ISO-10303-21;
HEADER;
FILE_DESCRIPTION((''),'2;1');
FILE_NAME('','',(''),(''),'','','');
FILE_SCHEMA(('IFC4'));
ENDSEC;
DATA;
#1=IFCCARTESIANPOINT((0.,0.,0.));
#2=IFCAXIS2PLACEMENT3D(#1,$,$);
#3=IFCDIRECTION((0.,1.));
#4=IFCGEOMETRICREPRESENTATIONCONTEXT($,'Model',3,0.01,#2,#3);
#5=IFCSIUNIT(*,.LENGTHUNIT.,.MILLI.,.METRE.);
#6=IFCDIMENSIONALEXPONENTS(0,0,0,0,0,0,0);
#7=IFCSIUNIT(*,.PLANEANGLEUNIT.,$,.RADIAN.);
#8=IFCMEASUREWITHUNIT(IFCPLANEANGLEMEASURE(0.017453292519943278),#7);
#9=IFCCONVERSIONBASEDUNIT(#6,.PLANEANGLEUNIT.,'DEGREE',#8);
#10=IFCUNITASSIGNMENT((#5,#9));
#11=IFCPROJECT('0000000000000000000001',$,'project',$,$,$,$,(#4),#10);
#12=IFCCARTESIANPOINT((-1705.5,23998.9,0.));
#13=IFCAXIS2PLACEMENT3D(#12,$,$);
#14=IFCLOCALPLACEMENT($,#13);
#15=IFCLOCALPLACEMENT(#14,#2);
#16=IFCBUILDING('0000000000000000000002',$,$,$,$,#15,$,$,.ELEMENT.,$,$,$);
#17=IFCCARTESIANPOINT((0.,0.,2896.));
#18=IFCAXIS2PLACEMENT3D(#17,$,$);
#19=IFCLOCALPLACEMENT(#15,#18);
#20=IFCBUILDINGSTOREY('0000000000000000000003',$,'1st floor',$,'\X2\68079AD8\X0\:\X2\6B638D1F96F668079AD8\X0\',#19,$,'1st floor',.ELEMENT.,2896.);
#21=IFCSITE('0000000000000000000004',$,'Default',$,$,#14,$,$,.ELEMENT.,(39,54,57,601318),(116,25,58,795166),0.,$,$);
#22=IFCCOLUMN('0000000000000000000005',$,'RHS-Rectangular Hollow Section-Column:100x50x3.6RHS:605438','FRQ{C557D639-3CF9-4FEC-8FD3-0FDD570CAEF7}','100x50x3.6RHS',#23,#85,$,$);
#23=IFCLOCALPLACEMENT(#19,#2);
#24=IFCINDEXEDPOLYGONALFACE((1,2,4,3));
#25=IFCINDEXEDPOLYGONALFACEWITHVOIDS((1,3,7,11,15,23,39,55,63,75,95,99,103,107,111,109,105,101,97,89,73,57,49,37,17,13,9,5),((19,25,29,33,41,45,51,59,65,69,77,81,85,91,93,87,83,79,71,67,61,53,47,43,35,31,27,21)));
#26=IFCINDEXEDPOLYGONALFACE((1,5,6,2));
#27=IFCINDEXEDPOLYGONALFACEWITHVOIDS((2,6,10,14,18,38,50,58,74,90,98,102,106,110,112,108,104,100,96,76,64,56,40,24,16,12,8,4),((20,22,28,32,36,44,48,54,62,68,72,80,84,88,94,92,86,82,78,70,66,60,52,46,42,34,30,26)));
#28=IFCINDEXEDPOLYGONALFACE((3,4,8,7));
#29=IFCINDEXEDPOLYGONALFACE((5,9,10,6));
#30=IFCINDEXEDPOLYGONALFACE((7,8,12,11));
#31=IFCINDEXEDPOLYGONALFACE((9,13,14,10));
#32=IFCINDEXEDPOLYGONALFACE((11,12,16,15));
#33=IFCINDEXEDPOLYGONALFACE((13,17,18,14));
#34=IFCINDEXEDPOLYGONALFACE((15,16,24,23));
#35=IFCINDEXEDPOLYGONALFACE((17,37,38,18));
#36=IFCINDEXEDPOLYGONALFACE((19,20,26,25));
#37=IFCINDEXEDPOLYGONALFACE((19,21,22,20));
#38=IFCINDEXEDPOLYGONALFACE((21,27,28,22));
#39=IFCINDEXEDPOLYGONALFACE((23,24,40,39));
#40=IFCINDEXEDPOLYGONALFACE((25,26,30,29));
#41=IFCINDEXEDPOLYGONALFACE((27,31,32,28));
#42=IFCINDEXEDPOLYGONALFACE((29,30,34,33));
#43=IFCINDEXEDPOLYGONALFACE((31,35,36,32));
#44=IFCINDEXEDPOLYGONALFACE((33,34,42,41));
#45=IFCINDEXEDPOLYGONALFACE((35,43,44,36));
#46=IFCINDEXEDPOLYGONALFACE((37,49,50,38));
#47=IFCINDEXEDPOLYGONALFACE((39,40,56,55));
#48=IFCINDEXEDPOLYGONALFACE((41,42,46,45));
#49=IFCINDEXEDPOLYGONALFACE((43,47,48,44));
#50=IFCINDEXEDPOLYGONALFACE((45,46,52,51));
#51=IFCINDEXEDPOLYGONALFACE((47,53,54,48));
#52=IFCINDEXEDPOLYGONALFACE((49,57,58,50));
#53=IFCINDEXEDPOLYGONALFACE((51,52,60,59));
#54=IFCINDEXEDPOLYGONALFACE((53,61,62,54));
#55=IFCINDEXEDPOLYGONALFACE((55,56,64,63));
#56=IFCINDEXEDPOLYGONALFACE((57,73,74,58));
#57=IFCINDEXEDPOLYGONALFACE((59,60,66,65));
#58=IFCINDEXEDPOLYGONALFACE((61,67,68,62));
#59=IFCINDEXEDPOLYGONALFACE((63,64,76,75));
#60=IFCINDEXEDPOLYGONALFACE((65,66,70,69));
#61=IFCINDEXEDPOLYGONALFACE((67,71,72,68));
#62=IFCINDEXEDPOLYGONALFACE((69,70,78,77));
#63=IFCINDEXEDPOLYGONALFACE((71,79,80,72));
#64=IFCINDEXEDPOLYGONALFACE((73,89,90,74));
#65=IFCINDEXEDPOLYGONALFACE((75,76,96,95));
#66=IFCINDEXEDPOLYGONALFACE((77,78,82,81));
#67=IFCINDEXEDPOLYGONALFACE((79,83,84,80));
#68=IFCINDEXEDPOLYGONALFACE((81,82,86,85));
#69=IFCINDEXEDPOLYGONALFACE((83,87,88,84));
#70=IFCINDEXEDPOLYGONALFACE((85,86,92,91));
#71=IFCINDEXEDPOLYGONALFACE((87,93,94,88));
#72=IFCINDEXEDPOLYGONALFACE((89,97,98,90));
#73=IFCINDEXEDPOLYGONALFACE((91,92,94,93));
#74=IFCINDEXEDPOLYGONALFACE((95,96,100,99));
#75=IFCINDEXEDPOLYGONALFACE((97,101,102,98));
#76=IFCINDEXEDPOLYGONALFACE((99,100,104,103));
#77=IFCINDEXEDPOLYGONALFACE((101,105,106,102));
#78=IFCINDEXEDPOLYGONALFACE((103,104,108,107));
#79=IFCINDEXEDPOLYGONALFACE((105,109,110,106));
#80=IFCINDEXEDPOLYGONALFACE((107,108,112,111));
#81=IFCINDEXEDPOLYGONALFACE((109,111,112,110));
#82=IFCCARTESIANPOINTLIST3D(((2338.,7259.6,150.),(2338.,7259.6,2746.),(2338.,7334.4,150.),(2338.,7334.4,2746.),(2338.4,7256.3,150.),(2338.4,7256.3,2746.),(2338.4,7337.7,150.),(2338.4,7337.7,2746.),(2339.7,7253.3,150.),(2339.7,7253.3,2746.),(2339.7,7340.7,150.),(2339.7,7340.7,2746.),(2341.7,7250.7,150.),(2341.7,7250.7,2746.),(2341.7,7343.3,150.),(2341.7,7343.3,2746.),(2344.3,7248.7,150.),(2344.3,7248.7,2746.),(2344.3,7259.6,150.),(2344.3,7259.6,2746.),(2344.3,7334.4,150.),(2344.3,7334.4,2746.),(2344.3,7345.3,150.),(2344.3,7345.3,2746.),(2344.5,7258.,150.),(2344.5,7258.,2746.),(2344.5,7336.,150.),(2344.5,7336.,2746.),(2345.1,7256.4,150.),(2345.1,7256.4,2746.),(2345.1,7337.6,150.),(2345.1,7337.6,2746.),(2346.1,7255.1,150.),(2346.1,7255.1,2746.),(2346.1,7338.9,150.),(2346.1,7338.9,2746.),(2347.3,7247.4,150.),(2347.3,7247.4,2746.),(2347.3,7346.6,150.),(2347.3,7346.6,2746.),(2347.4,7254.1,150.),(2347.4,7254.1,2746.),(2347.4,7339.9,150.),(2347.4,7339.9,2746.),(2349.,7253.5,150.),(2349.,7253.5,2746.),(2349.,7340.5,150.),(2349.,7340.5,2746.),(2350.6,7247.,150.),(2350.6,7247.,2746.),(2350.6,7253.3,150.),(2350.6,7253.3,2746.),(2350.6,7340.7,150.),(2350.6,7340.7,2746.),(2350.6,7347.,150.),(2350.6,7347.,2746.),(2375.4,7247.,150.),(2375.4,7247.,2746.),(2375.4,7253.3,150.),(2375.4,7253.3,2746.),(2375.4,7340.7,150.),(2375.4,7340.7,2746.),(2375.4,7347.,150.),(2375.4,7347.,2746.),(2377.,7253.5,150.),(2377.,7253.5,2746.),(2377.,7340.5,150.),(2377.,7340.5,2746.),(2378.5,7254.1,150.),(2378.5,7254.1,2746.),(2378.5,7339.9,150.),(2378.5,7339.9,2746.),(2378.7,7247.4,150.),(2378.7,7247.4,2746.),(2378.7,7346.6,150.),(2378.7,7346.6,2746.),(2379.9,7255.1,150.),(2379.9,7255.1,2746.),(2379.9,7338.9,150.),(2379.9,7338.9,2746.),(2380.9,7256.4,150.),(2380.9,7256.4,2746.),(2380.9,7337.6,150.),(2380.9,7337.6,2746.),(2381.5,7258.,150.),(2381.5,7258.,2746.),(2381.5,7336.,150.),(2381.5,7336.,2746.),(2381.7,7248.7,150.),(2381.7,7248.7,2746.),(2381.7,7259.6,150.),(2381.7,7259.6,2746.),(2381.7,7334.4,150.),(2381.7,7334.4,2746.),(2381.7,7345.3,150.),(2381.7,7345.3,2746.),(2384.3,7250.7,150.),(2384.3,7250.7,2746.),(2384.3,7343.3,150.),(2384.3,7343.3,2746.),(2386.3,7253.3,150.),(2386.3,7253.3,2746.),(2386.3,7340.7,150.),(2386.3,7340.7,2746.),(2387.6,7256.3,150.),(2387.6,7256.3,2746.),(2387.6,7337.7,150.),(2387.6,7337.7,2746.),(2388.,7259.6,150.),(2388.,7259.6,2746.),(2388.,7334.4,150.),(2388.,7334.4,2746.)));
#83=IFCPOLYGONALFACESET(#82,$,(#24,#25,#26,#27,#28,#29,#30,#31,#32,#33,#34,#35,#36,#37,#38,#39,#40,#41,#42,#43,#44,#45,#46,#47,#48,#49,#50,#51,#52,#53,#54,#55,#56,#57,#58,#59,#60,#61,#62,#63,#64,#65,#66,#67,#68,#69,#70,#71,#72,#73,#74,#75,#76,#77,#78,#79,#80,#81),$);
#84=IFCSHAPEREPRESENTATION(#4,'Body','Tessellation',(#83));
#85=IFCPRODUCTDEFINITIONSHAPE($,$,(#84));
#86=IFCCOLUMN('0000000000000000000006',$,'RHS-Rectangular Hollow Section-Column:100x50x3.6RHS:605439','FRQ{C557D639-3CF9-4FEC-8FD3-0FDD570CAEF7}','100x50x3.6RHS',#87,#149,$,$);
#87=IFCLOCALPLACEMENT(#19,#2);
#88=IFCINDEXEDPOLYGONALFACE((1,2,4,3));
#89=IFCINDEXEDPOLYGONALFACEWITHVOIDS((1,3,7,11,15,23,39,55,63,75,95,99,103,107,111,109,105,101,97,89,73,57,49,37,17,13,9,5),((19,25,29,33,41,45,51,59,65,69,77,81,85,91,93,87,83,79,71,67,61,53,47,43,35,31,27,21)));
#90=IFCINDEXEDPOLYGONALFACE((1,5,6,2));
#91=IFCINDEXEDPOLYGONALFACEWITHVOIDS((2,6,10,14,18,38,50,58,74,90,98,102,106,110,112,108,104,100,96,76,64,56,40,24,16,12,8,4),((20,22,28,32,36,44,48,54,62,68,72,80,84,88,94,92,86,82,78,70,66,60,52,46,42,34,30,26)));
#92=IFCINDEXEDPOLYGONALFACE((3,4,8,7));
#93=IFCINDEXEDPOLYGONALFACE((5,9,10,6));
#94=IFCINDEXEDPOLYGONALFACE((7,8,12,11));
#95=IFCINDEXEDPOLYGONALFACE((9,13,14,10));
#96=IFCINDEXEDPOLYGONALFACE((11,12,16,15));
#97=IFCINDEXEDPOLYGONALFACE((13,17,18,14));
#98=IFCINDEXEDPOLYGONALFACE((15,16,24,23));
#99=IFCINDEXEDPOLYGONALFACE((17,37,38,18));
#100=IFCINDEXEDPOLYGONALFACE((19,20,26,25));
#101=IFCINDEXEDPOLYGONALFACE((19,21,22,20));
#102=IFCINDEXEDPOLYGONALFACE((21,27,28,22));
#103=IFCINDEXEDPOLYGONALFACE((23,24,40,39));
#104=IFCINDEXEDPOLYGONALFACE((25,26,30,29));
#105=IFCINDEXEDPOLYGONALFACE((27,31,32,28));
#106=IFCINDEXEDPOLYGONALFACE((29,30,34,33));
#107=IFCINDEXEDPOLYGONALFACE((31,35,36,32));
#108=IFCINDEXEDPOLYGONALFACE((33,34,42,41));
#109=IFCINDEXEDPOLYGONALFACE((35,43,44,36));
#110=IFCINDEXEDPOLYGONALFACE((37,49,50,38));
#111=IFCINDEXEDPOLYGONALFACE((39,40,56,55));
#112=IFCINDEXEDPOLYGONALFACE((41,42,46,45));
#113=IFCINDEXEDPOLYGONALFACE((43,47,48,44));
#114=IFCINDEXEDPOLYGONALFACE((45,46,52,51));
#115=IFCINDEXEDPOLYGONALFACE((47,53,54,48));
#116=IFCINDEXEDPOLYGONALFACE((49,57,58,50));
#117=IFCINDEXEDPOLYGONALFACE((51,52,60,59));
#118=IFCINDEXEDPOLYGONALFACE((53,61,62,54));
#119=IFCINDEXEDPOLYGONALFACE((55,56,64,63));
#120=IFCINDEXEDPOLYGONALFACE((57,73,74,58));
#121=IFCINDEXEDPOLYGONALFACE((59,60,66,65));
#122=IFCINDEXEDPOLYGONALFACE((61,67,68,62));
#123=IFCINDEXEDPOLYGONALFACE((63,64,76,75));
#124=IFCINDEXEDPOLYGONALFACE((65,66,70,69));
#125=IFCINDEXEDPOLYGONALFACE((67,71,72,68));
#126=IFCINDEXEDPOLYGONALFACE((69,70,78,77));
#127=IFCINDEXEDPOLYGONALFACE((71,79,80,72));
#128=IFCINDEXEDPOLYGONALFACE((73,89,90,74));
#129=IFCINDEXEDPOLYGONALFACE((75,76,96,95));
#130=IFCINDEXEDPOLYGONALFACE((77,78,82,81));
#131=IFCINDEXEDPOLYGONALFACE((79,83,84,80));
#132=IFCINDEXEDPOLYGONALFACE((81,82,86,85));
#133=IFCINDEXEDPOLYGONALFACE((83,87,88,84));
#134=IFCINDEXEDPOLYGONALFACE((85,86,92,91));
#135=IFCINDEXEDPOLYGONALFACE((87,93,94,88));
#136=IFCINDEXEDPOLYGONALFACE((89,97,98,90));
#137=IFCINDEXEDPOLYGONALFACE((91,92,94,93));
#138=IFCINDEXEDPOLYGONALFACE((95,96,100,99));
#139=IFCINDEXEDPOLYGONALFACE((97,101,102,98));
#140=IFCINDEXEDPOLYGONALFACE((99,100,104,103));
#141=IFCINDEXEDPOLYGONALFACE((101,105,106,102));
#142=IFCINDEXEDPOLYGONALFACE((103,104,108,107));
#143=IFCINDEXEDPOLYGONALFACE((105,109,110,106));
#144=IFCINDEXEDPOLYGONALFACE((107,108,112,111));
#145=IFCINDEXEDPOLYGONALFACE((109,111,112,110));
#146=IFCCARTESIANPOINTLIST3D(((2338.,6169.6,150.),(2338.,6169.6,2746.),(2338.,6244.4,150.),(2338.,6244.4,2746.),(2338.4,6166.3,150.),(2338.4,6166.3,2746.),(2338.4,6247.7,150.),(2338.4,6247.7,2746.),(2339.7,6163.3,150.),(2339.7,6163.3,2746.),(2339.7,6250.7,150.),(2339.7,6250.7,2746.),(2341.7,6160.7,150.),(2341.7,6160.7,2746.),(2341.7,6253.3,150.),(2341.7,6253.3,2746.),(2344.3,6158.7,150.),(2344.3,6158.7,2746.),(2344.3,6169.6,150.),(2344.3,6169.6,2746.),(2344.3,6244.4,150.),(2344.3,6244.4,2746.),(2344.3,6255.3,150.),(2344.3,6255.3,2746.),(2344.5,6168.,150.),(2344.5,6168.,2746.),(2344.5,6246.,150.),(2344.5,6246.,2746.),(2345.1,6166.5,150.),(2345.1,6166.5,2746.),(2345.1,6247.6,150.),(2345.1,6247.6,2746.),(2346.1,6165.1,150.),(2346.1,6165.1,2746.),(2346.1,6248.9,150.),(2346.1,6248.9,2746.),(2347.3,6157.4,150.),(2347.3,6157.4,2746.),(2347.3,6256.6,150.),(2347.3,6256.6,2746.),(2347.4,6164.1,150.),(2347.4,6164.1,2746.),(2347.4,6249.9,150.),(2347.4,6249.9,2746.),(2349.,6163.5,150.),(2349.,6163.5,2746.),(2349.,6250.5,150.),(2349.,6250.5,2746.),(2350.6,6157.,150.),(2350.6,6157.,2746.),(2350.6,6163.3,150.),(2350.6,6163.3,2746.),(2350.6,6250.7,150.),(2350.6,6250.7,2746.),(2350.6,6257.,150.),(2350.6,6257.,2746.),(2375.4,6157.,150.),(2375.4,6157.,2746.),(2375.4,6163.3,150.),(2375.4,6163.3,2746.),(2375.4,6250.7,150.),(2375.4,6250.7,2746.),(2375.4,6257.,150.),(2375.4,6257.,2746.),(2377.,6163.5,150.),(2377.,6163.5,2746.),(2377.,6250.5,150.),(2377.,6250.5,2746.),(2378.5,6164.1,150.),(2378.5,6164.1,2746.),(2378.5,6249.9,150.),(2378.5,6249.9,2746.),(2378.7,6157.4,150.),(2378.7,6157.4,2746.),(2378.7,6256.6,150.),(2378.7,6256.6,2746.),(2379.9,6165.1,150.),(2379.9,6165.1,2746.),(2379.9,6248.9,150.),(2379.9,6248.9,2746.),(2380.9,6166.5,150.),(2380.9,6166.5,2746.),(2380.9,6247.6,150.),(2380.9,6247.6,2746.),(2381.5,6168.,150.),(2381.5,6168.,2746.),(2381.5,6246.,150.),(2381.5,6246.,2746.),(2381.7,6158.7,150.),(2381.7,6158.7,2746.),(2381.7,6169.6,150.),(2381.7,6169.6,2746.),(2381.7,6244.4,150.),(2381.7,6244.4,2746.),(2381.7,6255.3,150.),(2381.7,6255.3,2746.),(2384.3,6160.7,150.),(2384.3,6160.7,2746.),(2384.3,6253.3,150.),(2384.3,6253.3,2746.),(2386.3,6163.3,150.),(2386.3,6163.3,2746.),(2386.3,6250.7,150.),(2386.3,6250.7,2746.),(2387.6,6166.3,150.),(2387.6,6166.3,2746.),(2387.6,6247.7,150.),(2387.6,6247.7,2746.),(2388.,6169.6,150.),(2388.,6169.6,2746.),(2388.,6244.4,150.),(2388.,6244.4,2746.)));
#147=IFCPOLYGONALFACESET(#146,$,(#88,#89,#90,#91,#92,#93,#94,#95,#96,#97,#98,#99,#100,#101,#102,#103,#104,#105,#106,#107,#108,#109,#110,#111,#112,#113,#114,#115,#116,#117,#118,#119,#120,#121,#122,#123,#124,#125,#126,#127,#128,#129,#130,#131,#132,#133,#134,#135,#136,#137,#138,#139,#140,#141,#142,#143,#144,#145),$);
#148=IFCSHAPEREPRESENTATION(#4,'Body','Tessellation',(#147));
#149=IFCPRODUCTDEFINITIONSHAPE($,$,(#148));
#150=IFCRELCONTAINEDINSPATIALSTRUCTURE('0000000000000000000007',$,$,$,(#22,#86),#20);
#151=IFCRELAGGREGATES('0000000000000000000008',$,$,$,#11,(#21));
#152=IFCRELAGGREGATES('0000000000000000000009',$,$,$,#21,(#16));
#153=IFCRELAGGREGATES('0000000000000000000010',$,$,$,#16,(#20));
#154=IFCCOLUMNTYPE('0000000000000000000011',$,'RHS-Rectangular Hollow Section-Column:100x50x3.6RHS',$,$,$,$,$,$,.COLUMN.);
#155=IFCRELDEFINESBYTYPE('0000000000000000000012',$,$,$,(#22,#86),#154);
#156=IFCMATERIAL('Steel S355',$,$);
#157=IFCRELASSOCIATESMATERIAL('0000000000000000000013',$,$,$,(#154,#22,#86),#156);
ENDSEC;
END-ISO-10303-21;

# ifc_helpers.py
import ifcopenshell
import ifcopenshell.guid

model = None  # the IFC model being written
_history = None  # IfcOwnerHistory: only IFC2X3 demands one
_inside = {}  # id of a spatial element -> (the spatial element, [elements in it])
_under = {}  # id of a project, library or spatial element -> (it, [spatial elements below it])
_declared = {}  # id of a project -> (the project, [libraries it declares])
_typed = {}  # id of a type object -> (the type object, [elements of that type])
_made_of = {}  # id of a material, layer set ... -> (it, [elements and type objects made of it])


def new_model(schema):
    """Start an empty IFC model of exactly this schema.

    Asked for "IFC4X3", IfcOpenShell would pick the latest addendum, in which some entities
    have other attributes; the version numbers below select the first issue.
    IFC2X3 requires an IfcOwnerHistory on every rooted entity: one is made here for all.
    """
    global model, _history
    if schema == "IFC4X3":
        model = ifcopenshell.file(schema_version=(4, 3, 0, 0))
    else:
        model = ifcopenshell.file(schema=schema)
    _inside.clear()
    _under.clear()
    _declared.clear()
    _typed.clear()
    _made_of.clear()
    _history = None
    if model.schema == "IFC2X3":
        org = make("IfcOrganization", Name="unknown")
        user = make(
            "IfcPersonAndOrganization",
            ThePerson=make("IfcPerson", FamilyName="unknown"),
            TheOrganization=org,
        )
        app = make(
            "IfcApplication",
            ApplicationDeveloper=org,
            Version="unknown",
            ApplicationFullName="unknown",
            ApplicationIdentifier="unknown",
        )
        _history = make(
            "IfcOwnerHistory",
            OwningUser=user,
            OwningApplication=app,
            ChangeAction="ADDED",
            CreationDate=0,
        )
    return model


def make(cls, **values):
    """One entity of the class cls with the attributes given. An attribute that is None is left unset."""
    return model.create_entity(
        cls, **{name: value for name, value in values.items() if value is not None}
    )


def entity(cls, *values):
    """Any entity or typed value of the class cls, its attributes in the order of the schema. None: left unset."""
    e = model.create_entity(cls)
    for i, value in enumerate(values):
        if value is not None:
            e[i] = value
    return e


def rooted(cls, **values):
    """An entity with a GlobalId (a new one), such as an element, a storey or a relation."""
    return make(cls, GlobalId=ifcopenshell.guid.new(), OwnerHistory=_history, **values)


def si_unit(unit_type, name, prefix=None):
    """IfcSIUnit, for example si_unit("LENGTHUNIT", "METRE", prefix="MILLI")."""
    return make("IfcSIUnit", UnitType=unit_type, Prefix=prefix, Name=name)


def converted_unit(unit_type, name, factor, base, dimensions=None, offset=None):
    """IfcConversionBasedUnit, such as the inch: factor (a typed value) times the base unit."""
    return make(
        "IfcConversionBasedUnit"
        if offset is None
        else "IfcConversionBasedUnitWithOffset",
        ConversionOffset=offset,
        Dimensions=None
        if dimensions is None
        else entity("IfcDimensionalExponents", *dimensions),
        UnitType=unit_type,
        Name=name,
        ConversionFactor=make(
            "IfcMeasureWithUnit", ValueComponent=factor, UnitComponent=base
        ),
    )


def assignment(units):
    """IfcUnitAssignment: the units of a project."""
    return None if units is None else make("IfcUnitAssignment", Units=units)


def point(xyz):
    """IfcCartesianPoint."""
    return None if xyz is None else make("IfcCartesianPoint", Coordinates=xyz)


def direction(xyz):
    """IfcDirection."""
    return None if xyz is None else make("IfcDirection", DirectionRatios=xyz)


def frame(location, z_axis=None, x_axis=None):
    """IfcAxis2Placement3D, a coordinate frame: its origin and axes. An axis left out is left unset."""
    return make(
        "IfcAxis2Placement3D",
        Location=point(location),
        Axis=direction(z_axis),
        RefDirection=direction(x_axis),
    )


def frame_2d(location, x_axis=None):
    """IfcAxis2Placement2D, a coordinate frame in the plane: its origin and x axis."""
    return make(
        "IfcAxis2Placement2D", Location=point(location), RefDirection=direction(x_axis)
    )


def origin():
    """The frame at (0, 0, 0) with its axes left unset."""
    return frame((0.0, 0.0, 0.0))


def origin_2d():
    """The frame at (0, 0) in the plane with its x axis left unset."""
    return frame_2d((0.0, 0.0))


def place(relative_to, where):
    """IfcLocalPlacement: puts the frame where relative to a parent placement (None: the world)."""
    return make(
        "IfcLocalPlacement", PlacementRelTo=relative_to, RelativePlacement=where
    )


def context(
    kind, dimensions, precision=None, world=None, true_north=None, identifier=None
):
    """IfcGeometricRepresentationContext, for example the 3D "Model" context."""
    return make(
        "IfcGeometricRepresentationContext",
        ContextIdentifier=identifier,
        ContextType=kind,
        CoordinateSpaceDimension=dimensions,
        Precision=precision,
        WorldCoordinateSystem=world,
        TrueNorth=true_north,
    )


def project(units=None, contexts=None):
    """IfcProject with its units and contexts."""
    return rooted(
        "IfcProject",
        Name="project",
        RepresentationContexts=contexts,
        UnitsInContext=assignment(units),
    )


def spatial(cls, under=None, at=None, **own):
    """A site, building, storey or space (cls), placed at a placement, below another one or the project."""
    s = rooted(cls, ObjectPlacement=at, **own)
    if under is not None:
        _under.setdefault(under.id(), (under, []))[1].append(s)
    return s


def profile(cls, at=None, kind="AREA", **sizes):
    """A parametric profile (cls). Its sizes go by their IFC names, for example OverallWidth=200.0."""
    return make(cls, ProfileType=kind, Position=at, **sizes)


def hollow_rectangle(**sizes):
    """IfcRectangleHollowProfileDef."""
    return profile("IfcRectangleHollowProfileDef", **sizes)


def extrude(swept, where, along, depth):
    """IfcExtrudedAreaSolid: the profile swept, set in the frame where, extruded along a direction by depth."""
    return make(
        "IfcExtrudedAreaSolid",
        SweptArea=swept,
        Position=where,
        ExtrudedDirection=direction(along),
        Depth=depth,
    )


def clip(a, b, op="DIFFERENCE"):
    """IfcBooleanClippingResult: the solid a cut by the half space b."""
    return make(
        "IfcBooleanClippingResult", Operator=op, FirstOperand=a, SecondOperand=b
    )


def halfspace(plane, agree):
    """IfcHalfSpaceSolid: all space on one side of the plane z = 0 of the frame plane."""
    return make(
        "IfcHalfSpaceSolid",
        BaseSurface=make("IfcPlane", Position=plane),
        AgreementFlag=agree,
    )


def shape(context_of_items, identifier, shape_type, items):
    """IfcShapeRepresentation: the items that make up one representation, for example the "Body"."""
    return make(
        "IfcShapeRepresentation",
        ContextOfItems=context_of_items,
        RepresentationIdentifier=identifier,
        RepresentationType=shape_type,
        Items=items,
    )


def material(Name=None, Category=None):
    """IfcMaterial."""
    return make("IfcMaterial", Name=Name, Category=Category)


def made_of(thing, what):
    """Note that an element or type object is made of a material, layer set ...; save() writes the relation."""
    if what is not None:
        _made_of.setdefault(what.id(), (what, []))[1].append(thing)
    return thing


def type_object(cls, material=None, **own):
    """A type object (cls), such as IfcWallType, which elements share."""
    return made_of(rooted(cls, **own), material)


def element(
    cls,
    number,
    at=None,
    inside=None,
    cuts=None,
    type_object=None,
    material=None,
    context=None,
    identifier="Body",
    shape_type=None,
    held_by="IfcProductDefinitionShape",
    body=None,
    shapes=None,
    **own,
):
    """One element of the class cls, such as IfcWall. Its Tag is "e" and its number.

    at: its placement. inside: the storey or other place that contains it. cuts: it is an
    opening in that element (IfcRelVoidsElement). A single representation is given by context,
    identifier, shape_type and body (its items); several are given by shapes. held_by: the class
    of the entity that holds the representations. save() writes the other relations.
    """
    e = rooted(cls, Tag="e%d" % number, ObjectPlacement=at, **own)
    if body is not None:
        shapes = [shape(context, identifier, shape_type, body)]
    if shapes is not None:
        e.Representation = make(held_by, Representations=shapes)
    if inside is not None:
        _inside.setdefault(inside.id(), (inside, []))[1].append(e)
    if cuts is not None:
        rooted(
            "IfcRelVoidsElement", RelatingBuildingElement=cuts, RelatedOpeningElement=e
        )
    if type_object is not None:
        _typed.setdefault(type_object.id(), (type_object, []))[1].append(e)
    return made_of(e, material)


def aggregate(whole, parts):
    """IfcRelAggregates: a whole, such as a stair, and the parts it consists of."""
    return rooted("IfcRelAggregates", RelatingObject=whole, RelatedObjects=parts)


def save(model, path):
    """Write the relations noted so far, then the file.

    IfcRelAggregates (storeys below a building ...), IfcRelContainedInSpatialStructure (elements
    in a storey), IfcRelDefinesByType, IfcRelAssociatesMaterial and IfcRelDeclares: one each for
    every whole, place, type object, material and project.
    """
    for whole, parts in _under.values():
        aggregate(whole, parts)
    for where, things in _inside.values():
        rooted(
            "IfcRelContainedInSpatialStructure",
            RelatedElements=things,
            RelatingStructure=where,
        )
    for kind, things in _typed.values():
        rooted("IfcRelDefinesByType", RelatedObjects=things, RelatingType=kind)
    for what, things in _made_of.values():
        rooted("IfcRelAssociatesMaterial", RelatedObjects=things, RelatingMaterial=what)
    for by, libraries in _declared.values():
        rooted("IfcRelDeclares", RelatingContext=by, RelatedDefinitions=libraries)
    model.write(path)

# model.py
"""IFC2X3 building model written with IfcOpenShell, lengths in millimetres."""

from ifc_helpers import new_model, entity, si_unit, converted_unit, direction, frame, origin, origin_2d, place, context, project, spatial, hollow_rectangle, extrude, clip, halfspace, material, type_object, element, save


model = new_model("IFC2X3")

# Units and contexts
model_context = context("Model", 3, precision=0.01, world=origin(), true_north=direction((0.0, 1.0)))
ifc_project = project(units=[si_unit("LENGTHUNIT", "METRE", prefix="MILLI"), converted_unit("PLANEANGLEUNIT", "DEGREE", entity("IfcPlaneAngleMeasure", 0.017453292519943278), si_unit("PLANEANGLEUNIT", "RADIAN"), dimensions=[0, 0, 0, 0, 0, 0, 0])], contexts=[model_context])

# Site, building, storey
site_placement = place(None, frame((-1705.5, 23998.9, 0.0)))
site = spatial("IfcSite", under=ifc_project, at=site_placement, Name="Default", CompositionType="ELEMENT", RefLatitude=(39, 54, 57, 601318), RefLongitude=(116, 25, 58, 795166), RefElevation=0.0)
building_placement = place(site_placement, origin())
building = spatial("IfcBuilding", under=site, at=building_placement, CompositionType="ELEMENT")
storey_placement = place(building_placement, frame((0.0, 0.0, 2896.0)))
storey = spatial("IfcBuildingStorey", under=building, at=storey_placement, Name="1st floor", ObjectType="标高:正负零标高", LongName="1st floor", CompositionType="ELEMENT", Elevation=2896.0)

# Shared definitions
ifc_material_1 = material(Name="Steel S355")

# Columns
column_type_1 = type_object("IfcColumnType", Name="RHS-Rectangular Hollow Section-Column:100x50x3.6RHS", PredefinedType="COLUMN", material=ifc_material_1)
column_1_placement = place(storey_placement, frame((2363.0, 7297.0, 2746.0), z_axis=(0.0, 0.0, 1.0), x_axis=(-1.0, 0.0, 0.0)))
element("IfcColumn", 1, at=column_1_placement, inside=storey, type_object=column_type_1, material=ifc_material_1, Name="RHS-Rectangular Hollow Section-Column:100x50x3.6RHS:605438", Description="FRQ{C557D639-3CF9-4FEC-8FD3-0FDD570CAEF7}", ObjectType="100x50x3.6RHS", context=model_context, shape_type="Clipping", body=[
    clip(extrude(hollow_rectangle(XDim=50.0, YDim=100.0, WallThickness=6.3, InnerFilletRadius=6.3, OuterFilletRadius=12.6, at=origin_2d()), origin(), (0.0, 0.0, -1.0), 2651.9), halfspace(frame((2363.0, 7297.0, -2596.0), z_axis=(0.0, 0.0, 1.0), x_axis=(-1.0, 0.0, 0.0)), True)),
])
column_2_placement = place(storey_placement, frame((2363.0, 6207.0, 2746.0), z_axis=(0.0, 0.0, 1.0), x_axis=(-1.0, 0.0, 0.0)))
element("IfcColumn", 2, at=column_2_placement, inside=storey, type_object=column_type_1, material=ifc_material_1, Name="RHS-Rectangular Hollow Section-Column:100x50x3.6RHS:605439", Description="FRQ{C557D639-3CF9-4FEC-8FD3-0FDD570CAEF7}", ObjectType="100x50x3.6RHS", context=model_context, shape_type="Clipping", body=[
    clip(extrude(hollow_rectangle(XDim=50.0, YDim=100.0, WallThickness=6.3, InnerFilletRadius=6.3, OuterFilletRadius=12.6, at=origin_2d()), origin(), (0.0, 0.0, -1.0), 2651.9), halfspace(frame((2363.0, 6207.0, -2596.0), z_axis=(0.0, 0.0, 1.0), x_axis=(-1.0, 0.0, 0.0)), True)),
])

save(model, "model.ifc")
